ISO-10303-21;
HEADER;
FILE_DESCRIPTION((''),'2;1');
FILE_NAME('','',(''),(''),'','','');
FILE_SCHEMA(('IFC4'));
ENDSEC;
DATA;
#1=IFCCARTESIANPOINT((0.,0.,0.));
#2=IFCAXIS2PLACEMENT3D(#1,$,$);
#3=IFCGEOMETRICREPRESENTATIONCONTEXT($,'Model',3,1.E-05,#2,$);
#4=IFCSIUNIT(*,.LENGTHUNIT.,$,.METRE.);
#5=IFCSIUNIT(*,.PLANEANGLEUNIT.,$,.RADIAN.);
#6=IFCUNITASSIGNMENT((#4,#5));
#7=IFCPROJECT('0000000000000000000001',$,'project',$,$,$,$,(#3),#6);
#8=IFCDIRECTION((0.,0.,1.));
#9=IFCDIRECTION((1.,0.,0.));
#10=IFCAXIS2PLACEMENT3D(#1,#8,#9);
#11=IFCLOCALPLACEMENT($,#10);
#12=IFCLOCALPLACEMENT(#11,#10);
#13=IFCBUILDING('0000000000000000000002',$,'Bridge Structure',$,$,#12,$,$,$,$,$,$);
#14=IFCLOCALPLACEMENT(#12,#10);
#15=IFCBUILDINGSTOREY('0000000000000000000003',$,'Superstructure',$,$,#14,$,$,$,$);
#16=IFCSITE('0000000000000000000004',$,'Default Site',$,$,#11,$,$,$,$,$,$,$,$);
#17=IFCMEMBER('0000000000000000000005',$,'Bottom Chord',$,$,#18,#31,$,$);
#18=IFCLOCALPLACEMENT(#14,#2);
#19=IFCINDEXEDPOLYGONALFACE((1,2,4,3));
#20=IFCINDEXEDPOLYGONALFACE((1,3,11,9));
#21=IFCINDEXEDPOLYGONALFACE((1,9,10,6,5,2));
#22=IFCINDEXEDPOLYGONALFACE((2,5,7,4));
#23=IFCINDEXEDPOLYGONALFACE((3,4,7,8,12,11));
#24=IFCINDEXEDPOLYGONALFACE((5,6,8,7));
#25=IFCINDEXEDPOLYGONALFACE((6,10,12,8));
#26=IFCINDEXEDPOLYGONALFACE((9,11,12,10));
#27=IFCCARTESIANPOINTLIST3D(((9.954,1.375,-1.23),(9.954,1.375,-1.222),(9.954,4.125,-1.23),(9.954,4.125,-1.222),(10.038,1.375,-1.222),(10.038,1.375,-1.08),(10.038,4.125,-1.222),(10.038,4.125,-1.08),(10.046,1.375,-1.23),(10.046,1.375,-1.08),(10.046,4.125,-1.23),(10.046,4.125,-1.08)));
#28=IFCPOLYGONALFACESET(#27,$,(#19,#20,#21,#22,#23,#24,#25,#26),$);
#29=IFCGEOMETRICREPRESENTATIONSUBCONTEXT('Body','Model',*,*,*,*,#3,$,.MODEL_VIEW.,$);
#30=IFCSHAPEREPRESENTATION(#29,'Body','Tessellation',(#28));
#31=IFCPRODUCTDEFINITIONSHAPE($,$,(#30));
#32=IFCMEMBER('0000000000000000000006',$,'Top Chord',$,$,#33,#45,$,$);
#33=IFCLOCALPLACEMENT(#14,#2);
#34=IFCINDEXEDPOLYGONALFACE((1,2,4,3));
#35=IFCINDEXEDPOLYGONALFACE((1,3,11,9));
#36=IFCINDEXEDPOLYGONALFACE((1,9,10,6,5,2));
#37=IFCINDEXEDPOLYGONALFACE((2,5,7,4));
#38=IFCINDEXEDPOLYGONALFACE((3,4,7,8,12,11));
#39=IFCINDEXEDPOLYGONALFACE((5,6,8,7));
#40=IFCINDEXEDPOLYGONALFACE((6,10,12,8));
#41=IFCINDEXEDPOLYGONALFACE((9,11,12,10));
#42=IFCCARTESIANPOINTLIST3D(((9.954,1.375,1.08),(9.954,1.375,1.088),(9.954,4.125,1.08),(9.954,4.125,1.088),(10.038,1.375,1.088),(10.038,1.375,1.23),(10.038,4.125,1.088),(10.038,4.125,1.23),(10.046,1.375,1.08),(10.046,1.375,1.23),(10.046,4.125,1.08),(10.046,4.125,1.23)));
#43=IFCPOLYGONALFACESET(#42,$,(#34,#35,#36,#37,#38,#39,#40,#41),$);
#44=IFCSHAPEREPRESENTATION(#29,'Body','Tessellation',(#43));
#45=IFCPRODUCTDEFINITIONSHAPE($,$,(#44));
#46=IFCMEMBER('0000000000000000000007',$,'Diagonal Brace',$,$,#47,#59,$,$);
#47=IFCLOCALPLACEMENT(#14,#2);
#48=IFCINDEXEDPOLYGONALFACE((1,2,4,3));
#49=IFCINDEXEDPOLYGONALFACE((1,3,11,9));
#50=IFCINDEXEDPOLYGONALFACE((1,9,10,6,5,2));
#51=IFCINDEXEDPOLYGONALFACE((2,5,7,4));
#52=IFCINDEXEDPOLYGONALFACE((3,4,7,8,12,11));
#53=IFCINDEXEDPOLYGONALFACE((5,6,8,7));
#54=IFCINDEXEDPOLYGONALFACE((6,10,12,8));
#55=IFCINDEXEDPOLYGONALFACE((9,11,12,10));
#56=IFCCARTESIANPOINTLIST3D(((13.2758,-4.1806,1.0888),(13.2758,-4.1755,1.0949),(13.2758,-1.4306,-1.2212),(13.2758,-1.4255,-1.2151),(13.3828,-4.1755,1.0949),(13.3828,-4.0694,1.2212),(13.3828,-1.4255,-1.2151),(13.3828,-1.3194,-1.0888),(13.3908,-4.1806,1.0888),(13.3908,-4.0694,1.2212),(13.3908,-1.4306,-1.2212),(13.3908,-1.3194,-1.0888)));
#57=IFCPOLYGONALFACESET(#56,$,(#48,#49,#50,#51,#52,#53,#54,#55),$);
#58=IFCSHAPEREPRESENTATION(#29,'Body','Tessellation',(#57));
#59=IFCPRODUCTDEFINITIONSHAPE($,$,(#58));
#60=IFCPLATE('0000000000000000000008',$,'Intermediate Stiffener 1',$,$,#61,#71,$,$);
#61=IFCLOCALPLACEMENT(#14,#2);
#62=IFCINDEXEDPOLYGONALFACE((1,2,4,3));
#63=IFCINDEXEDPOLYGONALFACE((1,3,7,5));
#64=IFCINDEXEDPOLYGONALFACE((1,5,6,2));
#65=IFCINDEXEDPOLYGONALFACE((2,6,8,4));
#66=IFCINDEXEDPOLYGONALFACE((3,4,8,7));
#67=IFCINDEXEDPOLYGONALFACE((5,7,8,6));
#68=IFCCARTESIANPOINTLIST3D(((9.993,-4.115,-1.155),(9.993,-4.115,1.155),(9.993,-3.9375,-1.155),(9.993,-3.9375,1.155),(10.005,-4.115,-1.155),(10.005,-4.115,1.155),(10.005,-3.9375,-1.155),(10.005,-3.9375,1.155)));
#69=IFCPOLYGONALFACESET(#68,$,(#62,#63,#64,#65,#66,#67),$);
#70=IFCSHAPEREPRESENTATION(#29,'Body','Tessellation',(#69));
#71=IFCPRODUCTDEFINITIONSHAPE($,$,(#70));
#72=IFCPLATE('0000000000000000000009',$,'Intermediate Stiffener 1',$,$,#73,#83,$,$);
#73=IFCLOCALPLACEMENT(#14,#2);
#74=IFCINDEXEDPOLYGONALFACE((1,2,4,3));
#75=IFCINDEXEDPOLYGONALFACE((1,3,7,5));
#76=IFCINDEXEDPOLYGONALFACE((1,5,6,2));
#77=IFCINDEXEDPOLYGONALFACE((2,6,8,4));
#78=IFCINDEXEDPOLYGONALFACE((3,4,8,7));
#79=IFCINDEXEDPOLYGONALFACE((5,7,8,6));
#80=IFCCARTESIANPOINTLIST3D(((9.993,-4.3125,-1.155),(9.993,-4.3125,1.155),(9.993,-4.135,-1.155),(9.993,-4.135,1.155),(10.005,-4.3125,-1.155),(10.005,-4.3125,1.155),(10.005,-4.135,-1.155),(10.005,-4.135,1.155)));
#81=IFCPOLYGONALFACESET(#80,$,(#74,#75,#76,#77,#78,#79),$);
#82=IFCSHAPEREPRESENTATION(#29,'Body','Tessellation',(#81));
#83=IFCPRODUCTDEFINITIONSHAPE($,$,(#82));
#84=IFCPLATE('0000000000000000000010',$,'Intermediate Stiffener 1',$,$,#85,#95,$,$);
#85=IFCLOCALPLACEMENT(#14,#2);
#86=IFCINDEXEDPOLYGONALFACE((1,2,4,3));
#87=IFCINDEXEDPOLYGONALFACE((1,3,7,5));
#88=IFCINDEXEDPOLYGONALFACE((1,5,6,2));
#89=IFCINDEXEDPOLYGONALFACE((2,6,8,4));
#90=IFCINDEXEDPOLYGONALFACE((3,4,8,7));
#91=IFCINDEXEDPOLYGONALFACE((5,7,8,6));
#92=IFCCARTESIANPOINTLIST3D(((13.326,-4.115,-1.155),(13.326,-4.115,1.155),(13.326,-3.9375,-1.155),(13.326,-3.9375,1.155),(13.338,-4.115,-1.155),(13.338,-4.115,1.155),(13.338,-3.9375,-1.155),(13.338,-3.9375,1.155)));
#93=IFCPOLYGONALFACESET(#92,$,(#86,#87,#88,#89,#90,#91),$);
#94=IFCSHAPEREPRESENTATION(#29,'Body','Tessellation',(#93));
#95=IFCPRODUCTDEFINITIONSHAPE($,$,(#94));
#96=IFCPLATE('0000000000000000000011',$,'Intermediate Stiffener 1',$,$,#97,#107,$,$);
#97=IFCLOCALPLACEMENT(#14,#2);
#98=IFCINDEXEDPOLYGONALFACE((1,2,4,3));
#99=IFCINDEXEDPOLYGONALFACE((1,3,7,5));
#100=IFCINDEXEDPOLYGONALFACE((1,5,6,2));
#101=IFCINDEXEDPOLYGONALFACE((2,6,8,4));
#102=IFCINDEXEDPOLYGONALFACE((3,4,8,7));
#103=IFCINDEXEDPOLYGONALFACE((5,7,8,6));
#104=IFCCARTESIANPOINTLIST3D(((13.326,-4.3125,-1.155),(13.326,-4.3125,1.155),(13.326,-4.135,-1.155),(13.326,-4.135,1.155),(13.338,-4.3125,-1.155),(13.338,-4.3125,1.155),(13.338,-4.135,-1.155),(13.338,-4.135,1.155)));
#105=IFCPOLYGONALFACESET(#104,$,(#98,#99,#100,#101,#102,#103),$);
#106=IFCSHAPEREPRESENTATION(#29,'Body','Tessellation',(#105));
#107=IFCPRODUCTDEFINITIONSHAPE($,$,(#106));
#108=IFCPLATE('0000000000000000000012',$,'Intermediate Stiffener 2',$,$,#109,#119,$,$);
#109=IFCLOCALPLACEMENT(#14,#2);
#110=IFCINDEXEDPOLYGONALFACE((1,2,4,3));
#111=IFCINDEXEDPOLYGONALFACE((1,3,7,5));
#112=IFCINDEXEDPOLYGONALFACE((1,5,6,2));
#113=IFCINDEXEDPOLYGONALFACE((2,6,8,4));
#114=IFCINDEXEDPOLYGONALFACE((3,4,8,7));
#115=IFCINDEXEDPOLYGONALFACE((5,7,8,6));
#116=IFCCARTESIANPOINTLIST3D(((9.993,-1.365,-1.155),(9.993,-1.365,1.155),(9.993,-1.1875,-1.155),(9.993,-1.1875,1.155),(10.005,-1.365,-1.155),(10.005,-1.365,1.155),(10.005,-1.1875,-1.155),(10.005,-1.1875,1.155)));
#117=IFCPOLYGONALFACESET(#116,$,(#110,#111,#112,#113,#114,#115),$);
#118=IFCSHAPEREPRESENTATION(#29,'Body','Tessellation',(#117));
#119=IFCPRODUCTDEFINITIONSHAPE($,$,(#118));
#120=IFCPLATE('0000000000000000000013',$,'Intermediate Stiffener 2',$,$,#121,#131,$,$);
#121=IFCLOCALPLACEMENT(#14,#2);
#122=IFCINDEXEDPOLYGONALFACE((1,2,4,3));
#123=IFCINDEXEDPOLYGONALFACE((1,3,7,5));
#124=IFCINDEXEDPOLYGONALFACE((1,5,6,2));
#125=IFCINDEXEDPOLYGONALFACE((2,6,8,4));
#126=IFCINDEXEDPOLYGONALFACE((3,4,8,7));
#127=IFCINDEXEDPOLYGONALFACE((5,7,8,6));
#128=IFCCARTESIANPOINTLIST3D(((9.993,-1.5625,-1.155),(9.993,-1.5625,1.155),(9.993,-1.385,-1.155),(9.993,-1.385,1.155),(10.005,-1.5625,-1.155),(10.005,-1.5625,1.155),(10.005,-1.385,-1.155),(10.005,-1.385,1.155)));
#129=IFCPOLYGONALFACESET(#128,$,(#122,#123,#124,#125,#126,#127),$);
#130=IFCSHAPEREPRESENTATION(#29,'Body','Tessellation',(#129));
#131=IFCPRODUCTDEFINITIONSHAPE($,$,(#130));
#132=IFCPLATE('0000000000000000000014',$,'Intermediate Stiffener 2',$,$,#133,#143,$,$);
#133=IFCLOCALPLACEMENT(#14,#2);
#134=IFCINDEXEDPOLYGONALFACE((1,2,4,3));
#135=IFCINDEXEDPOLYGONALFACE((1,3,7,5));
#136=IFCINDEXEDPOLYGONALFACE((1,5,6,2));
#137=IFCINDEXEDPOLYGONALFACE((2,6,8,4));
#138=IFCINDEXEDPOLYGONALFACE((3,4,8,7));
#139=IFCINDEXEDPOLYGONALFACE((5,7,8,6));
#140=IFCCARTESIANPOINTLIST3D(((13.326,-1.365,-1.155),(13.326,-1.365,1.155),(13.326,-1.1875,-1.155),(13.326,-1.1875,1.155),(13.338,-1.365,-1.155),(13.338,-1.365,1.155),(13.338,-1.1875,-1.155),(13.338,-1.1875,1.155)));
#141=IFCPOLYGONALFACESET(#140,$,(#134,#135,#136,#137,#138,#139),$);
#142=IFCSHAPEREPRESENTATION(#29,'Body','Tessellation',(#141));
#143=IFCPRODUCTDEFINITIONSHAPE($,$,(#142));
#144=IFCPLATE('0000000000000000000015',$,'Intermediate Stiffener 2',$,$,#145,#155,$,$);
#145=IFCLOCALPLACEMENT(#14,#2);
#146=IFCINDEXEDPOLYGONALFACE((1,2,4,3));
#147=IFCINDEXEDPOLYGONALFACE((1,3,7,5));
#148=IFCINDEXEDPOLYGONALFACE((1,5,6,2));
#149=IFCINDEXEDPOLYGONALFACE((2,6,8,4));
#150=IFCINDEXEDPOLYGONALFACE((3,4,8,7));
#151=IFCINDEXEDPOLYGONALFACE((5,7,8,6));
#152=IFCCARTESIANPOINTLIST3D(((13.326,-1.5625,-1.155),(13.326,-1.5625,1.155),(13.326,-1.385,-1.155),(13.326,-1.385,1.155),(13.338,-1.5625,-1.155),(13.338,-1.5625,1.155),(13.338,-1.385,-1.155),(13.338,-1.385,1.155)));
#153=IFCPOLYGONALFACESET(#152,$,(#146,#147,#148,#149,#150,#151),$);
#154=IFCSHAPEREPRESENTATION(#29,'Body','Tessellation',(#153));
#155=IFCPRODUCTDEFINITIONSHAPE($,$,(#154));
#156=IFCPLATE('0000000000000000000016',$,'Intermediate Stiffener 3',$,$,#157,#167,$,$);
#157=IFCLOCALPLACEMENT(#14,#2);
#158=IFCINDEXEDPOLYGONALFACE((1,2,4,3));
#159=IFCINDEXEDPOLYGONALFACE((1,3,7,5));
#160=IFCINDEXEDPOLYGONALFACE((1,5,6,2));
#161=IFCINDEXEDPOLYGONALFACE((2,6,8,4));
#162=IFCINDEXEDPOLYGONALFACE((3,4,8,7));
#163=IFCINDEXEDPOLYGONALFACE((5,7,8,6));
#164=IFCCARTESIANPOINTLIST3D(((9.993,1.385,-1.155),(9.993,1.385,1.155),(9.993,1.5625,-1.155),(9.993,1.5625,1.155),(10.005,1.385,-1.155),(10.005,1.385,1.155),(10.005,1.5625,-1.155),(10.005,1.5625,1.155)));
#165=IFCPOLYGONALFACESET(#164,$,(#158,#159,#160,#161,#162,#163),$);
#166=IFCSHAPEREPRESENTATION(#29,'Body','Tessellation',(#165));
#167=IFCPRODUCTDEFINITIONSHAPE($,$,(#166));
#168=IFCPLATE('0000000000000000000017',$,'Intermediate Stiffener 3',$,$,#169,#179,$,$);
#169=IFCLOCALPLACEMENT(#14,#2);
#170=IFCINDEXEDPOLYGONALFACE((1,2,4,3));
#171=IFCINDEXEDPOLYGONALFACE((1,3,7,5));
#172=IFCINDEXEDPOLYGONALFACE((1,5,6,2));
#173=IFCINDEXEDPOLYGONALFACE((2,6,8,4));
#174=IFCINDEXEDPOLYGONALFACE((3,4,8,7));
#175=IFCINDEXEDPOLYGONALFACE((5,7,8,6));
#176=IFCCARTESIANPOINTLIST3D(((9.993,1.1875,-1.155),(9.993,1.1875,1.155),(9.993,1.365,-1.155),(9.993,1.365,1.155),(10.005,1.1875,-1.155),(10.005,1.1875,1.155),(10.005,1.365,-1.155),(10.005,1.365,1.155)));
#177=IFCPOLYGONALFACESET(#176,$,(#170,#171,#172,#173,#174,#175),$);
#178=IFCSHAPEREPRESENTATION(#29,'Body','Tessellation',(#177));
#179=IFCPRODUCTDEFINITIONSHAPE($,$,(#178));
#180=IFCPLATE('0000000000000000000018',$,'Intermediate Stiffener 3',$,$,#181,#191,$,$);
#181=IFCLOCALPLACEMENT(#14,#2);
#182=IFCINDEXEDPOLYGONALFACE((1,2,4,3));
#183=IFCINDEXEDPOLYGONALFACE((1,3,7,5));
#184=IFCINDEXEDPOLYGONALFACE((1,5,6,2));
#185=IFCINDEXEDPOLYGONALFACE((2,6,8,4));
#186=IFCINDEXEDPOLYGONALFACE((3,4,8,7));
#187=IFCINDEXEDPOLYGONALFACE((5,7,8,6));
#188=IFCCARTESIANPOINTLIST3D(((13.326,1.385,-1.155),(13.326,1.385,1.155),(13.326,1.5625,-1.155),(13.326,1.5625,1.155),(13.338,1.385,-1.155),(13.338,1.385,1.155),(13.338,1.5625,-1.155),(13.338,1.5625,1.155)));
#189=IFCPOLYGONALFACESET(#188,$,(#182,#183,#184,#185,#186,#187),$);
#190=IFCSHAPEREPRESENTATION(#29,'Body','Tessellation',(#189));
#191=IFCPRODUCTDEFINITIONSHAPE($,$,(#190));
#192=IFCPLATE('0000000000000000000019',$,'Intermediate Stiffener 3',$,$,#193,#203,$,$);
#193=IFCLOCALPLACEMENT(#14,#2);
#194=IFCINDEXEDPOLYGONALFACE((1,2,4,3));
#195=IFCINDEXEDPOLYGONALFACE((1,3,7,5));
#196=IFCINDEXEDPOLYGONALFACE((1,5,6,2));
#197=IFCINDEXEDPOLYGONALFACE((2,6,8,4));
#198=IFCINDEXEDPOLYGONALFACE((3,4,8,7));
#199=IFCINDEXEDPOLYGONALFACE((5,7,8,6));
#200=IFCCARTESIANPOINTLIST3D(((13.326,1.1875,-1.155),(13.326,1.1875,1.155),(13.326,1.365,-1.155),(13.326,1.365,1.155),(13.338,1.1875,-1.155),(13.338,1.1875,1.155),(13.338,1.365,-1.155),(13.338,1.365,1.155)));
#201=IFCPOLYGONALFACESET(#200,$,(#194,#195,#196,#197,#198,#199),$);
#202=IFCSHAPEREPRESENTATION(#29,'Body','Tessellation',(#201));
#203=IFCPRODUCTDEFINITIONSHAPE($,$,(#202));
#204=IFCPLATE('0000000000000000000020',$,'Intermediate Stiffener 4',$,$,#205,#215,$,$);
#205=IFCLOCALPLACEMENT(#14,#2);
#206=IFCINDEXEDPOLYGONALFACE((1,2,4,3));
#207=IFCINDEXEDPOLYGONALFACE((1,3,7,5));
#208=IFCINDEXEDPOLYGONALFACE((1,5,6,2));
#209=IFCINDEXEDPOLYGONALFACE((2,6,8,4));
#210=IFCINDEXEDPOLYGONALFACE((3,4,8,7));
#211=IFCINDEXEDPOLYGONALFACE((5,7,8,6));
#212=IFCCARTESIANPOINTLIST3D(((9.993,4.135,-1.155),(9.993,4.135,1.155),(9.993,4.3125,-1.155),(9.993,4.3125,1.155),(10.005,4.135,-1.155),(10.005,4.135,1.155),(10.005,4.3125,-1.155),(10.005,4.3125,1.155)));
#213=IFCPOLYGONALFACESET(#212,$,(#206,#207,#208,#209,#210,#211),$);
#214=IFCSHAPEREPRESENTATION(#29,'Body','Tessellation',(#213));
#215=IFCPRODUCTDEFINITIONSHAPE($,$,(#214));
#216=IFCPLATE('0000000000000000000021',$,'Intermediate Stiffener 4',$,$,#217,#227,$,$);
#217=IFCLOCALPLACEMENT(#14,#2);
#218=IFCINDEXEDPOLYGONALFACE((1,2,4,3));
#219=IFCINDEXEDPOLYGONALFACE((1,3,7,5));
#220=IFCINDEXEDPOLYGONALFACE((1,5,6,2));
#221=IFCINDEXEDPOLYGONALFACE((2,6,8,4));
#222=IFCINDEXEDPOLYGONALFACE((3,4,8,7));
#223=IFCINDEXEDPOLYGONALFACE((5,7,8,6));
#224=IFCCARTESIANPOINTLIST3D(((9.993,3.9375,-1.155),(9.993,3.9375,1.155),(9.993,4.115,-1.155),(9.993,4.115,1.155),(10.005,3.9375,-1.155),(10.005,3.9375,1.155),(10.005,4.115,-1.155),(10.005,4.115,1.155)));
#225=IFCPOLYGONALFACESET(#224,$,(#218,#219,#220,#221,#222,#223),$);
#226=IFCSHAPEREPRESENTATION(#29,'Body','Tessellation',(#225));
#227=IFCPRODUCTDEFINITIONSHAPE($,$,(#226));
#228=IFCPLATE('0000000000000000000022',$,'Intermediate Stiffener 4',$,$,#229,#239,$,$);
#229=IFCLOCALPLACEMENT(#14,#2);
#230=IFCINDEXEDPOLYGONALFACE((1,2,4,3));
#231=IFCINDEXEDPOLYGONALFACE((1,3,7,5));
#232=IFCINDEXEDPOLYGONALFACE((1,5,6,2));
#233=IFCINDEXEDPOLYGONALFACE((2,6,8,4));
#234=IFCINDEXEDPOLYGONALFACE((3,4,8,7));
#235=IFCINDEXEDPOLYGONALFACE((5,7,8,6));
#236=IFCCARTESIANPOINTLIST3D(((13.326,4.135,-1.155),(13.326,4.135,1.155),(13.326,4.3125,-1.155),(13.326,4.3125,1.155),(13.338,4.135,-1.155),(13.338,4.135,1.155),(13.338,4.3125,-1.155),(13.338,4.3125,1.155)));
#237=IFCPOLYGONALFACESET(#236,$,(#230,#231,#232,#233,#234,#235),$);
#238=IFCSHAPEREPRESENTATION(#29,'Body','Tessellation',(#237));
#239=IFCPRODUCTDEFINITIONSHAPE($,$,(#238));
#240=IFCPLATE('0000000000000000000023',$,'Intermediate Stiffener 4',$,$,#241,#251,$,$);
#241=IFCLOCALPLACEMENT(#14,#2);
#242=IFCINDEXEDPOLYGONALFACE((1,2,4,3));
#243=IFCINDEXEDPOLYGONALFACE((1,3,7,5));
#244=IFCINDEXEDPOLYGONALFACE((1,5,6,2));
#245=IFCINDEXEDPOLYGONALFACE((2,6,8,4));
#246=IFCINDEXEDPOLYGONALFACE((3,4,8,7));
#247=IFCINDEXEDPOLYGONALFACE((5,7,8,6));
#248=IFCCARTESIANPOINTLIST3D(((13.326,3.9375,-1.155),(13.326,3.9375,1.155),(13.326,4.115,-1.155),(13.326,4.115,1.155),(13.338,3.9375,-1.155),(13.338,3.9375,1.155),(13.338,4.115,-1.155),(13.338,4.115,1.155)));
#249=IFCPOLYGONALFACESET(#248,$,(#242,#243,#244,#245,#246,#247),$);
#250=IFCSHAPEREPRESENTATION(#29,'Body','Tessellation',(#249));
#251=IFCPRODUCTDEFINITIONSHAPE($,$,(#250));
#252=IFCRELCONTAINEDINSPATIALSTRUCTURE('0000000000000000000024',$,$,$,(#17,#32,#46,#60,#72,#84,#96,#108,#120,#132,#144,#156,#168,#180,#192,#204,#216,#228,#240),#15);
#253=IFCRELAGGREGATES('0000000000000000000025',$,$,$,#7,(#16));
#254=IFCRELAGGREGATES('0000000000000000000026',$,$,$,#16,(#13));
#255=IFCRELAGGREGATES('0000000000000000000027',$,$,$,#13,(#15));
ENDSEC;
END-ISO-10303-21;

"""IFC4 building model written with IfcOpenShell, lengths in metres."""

from ifc_helpers import new_model, si_unit, frame, origin, origin_with_axes, origin_2d_with_axis, place, context, subcontext, project, spatial, rectangle, l_section, extrude, element, save


model = new_model("IFC4")

# Units and contexts
model_context = context("Model", 3, precision=1e-05, world=origin())
body_context = subcontext(model_context, "Body", "Model", "MODEL_VIEW")
ifc_project = project(units=[si_unit("LENGTHUNIT", "METRE"), si_unit("PLANEANGLEUNIT", "RADIAN")], contexts=[model_context])

# Site, building, storey
site_placement = place(None, origin_with_axes())
site = spatial("IfcSite", under=ifc_project, at=site_placement, Name="Default Site")
building_placement = place(site_placement, origin_with_axes())
building = spatial("IfcBuilding", under=site, at=building_placement, Name="Bridge Structure")
storey_placement = place(building_placement, origin_with_axes())
storey = spatial("IfcBuildingStorey", under=building, at=storey_placement, Name="Superstructure")

# Members
for number, where, z_axis, x_axis, name in (
    (1, (10.0, 1.375, -1.155), (0.0, 1.0, 0.0), (-1.0, 0.0, 0.0), "Bottom Chord"),
    (2, (10.0, 1.375, 1.155), (0.0, 1.0, 0.0), (-1.0, 0.0, 0.0), "Top Chord"),
):
    element("IfcMember", number, at=place(storey_placement, frame(where, z_axis=z_axis, x_axis=x_axis)), inside=storey, Name=name, context=body_context, shape_type="SweptSolid", body=[
        extrude(l_section(Depth=0.15, Width=0.092, Thickness=0.008, at=origin_2d_with_axis()), origin_with_axes(), (0.0, 0.0, 1.0), 2.75),
    ])
member_1_placement = place(storey_placement, frame((13.3333, -4.125, 1.155), z_axis=(0.0, 0.765705, -0.643192), x_axis=(-1.0, 0.0, 0.0)))
element("IfcMember", 3, at=member_1_placement, inside=storey, Name="Diagonal Brace", context=body_context, shape_type="SweptSolid", body=[
    extrude(l_section(Depth=0.173, Width=0.115, Thickness=0.008, at=origin_2d_with_axis()), origin_with_axes(), (0.0, 0.0, 1.0), 3.5915),
])

# Plates
for number, where, z_axis, x_axis, name in (
    (4, (9.999, -4.0263, -1.155), (0.0, 0.0, 1.0), (1.0, 0.0, 0.0), "Intermediate Stiffener 1"),
    (5, (9.999, -4.2237, -1.155), (0.0, 0.0, 1.0), (1.0, 0.0, 0.0), "Intermediate Stiffener 1"),
    (6, (13.332, -4.0263, -1.155), (0.0, 0.0, 1.0), (1.0, 0.0, 0.0), "Intermediate Stiffener 1"),
    (7, (13.332, -4.2237, -1.155), (0.0, 0.0, 1.0), (1.0, 0.0, 0.0), "Intermediate Stiffener 1"),
    (8, (9.999, -1.2763, -1.155), (0.0, 0.0, 1.0), (1.0, 0.0, 0.0), "Intermediate Stiffener 2"),
    (9, (9.999, -1.4738, -1.155), (0.0, 0.0, 1.0), (1.0, 0.0, 0.0), "Intermediate Stiffener 2"),
    (10, (13.332, -1.2763, -1.155), (0.0, 0.0, 1.0), (1.0, 0.0, 0.0), "Intermediate Stiffener 2"),
    (11, (13.332, -1.4738, -1.155), (0.0, 0.0, 1.0), (1.0, 0.0, 0.0), "Intermediate Stiffener 2"),
    (12, (9.999, 1.4738, -1.155), (0.0, 0.0, 1.0), (1.0, 0.0, 0.0), "Intermediate Stiffener 3"),
    (13, (9.999, 1.2763, -1.155), (0.0, 0.0, 1.0), (1.0, 0.0, 0.0), "Intermediate Stiffener 3"),
    (14, (13.332, 1.4738, -1.155), (0.0, 0.0, 1.0), (1.0, 0.0, 0.0), "Intermediate Stiffener 3"),
    (15, (13.332, 1.2763, -1.155), (0.0, 0.0, 1.0), (1.0, 0.0, 0.0), "Intermediate Stiffener 3"),
    (16, (9.999, 4.2237, -1.155), (0.0, 0.0, 1.0), (1.0, 0.0, 0.0), "Intermediate Stiffener 4"),
    (17, (9.999, 4.0263, -1.155), (0.0, 0.0, 1.0), (1.0, 0.0, 0.0), "Intermediate Stiffener 4"),
    (18, (13.332, 4.2237, -1.155), (0.0, 0.0, 1.0), (1.0, 0.0, 0.0), "Intermediate Stiffener 4"),
    (19, (13.332, 4.0263, -1.155), (0.0, 0.0, 1.0), (1.0, 0.0, 0.0), "Intermediate Stiffener 4"),
):
    element("IfcPlate", number, at=place(storey_placement, frame(where, z_axis=z_axis, x_axis=x_axis)), inside=storey, Name=name, context=body_context, shape_type="SweptSolid", body=[
        extrude(rectangle(XDim=0.012, YDim=0.1775, at=origin_2d_with_axis()), origin_with_axes(), (0.0, 0.0, 1.0), 2.31),
    ])

save(model, "model.ifc")
